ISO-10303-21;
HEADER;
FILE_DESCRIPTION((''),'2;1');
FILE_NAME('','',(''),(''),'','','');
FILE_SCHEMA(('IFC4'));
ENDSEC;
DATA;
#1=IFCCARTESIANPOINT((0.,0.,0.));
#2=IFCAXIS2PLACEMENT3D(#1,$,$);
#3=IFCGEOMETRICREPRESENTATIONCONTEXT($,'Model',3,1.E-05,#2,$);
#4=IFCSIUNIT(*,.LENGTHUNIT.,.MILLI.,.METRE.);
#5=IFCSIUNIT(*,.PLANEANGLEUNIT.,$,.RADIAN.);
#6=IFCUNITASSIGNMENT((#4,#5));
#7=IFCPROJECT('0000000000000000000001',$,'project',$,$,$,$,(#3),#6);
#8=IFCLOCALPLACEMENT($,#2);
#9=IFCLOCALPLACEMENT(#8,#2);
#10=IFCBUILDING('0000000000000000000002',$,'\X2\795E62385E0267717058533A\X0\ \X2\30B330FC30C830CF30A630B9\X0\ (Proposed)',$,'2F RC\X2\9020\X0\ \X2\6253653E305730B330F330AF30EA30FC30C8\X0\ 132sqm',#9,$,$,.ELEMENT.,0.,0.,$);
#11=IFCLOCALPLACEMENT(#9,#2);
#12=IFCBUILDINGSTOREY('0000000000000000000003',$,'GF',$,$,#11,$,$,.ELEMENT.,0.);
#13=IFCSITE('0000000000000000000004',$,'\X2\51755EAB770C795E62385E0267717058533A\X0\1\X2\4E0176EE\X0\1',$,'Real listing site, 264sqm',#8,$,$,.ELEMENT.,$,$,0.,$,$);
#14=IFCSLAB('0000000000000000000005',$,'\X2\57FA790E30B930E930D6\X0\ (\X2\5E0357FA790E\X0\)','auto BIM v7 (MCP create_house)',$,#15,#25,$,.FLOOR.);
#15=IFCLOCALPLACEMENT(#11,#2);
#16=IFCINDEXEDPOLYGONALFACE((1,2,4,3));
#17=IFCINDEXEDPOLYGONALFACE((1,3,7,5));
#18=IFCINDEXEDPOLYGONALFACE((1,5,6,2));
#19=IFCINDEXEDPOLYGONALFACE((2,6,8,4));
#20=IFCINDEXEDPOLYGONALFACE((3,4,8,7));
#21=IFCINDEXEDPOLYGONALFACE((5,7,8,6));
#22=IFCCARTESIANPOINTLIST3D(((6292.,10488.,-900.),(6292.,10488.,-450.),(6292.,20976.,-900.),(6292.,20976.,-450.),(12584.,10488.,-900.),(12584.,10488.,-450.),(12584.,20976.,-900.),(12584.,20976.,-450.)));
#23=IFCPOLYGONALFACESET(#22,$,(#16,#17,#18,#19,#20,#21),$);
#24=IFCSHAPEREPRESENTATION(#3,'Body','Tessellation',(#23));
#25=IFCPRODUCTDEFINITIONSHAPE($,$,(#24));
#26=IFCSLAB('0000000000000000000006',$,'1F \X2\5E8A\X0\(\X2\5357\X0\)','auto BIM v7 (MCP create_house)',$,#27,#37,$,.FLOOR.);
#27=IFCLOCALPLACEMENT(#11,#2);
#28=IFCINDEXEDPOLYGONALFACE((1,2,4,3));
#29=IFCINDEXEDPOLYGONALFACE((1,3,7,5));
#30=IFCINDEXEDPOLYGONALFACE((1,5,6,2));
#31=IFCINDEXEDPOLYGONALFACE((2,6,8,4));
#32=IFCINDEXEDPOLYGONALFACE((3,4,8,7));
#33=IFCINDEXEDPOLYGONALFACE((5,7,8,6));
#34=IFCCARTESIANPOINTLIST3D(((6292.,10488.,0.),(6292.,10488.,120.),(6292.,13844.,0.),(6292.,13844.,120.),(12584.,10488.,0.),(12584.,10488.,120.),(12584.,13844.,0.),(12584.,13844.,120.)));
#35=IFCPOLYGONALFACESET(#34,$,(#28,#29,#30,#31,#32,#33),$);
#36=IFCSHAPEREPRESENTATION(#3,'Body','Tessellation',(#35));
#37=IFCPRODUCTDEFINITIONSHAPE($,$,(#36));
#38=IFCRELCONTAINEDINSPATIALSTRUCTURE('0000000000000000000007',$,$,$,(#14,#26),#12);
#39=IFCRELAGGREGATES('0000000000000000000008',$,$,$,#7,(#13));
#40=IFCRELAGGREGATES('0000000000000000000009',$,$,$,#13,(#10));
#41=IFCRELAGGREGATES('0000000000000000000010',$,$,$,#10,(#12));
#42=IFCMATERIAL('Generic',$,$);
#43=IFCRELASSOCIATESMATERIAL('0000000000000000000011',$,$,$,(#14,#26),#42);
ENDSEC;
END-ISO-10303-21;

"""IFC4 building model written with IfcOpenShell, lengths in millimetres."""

from ifc_helpers import new_model, si_unit, frame, frame_2d, origin, place, context, project, spatial, rectangle, extrude, material, element, save


model = new_model("IFC4")

# Units and contexts
model_context = context("Model", 3, precision=1e-05, world=origin())
ifc_project = project(units=[si_unit("LENGTHUNIT", "METRE", prefix="MILLI"), si_unit("PLANEANGLEUNIT", "RADIAN")], contexts=[model_context])

# Site, building, storey
site_placement = place(None, origin())
site = spatial("IfcSite", under=ifc_project, at=site_placement, Name="兵庫県神戸市東灘区1丁目1", ObjectType="Real listing site, 264sqm", CompositionType="ELEMENT", RefElevation=0.0)
building_placement = place(site_placement, origin())
building = spatial("IfcBuilding", under=site, at=building_placement, Name="神戸市東灘区 コートハウス (Proposed)", ObjectType="2F RC造 打放しコンクリート 132sqm", CompositionType="ELEMENT", ElevationOfRefHeight=0.0, ElevationOfTerrain=0.0)
storey_placement = place(building_placement, origin())
storey = spatial("IfcBuildingStorey", under=building, at=storey_placement, Name="GF", CompositionType="ELEMENT", Elevation=0.0)

# Slabs
ifc_material = material(Name="Generic")
slab_1_placement = place(storey_placement, frame((3146.0, 5244.0, -450.0)))
element("IfcSlab", 1, at=slab_1_placement, inside=storey, material=ifc_material, Name="基礎スラブ (布基礎)", Description="auto BIM v7 (MCP create_house)", PredefinedType="FLOOR", context=model_context, shape_type="SweptSolid", body=[
    extrude(rectangle(XDim=6292.0, YDim=10488.0, at=frame_2d((3146.0, 5244.0))), frame((3146.0, 5244.0, -450.0)), (0.0, 0.0, 1.0), 450.0),
])
slab_2_placement = place(storey_placement, frame((3146.0, 5244.0, 0.0)))
element("IfcSlab", 2, at=slab_2_placement, inside=storey, material=ifc_material, Name="1F 床(南)", Description="auto BIM v7 (MCP create_house)", PredefinedType="FLOOR", context=model_context, shape_type="SweptSolid", body=[
    extrude(rectangle(XDim=6292.0, YDim=3356.0, at=frame_2d((3146.0, 1678.0))), frame((3146.0, 5244.0, 0.0)), (0.0, 0.0, 1.0), 120.0),
])

save(model, "model.ifc")
